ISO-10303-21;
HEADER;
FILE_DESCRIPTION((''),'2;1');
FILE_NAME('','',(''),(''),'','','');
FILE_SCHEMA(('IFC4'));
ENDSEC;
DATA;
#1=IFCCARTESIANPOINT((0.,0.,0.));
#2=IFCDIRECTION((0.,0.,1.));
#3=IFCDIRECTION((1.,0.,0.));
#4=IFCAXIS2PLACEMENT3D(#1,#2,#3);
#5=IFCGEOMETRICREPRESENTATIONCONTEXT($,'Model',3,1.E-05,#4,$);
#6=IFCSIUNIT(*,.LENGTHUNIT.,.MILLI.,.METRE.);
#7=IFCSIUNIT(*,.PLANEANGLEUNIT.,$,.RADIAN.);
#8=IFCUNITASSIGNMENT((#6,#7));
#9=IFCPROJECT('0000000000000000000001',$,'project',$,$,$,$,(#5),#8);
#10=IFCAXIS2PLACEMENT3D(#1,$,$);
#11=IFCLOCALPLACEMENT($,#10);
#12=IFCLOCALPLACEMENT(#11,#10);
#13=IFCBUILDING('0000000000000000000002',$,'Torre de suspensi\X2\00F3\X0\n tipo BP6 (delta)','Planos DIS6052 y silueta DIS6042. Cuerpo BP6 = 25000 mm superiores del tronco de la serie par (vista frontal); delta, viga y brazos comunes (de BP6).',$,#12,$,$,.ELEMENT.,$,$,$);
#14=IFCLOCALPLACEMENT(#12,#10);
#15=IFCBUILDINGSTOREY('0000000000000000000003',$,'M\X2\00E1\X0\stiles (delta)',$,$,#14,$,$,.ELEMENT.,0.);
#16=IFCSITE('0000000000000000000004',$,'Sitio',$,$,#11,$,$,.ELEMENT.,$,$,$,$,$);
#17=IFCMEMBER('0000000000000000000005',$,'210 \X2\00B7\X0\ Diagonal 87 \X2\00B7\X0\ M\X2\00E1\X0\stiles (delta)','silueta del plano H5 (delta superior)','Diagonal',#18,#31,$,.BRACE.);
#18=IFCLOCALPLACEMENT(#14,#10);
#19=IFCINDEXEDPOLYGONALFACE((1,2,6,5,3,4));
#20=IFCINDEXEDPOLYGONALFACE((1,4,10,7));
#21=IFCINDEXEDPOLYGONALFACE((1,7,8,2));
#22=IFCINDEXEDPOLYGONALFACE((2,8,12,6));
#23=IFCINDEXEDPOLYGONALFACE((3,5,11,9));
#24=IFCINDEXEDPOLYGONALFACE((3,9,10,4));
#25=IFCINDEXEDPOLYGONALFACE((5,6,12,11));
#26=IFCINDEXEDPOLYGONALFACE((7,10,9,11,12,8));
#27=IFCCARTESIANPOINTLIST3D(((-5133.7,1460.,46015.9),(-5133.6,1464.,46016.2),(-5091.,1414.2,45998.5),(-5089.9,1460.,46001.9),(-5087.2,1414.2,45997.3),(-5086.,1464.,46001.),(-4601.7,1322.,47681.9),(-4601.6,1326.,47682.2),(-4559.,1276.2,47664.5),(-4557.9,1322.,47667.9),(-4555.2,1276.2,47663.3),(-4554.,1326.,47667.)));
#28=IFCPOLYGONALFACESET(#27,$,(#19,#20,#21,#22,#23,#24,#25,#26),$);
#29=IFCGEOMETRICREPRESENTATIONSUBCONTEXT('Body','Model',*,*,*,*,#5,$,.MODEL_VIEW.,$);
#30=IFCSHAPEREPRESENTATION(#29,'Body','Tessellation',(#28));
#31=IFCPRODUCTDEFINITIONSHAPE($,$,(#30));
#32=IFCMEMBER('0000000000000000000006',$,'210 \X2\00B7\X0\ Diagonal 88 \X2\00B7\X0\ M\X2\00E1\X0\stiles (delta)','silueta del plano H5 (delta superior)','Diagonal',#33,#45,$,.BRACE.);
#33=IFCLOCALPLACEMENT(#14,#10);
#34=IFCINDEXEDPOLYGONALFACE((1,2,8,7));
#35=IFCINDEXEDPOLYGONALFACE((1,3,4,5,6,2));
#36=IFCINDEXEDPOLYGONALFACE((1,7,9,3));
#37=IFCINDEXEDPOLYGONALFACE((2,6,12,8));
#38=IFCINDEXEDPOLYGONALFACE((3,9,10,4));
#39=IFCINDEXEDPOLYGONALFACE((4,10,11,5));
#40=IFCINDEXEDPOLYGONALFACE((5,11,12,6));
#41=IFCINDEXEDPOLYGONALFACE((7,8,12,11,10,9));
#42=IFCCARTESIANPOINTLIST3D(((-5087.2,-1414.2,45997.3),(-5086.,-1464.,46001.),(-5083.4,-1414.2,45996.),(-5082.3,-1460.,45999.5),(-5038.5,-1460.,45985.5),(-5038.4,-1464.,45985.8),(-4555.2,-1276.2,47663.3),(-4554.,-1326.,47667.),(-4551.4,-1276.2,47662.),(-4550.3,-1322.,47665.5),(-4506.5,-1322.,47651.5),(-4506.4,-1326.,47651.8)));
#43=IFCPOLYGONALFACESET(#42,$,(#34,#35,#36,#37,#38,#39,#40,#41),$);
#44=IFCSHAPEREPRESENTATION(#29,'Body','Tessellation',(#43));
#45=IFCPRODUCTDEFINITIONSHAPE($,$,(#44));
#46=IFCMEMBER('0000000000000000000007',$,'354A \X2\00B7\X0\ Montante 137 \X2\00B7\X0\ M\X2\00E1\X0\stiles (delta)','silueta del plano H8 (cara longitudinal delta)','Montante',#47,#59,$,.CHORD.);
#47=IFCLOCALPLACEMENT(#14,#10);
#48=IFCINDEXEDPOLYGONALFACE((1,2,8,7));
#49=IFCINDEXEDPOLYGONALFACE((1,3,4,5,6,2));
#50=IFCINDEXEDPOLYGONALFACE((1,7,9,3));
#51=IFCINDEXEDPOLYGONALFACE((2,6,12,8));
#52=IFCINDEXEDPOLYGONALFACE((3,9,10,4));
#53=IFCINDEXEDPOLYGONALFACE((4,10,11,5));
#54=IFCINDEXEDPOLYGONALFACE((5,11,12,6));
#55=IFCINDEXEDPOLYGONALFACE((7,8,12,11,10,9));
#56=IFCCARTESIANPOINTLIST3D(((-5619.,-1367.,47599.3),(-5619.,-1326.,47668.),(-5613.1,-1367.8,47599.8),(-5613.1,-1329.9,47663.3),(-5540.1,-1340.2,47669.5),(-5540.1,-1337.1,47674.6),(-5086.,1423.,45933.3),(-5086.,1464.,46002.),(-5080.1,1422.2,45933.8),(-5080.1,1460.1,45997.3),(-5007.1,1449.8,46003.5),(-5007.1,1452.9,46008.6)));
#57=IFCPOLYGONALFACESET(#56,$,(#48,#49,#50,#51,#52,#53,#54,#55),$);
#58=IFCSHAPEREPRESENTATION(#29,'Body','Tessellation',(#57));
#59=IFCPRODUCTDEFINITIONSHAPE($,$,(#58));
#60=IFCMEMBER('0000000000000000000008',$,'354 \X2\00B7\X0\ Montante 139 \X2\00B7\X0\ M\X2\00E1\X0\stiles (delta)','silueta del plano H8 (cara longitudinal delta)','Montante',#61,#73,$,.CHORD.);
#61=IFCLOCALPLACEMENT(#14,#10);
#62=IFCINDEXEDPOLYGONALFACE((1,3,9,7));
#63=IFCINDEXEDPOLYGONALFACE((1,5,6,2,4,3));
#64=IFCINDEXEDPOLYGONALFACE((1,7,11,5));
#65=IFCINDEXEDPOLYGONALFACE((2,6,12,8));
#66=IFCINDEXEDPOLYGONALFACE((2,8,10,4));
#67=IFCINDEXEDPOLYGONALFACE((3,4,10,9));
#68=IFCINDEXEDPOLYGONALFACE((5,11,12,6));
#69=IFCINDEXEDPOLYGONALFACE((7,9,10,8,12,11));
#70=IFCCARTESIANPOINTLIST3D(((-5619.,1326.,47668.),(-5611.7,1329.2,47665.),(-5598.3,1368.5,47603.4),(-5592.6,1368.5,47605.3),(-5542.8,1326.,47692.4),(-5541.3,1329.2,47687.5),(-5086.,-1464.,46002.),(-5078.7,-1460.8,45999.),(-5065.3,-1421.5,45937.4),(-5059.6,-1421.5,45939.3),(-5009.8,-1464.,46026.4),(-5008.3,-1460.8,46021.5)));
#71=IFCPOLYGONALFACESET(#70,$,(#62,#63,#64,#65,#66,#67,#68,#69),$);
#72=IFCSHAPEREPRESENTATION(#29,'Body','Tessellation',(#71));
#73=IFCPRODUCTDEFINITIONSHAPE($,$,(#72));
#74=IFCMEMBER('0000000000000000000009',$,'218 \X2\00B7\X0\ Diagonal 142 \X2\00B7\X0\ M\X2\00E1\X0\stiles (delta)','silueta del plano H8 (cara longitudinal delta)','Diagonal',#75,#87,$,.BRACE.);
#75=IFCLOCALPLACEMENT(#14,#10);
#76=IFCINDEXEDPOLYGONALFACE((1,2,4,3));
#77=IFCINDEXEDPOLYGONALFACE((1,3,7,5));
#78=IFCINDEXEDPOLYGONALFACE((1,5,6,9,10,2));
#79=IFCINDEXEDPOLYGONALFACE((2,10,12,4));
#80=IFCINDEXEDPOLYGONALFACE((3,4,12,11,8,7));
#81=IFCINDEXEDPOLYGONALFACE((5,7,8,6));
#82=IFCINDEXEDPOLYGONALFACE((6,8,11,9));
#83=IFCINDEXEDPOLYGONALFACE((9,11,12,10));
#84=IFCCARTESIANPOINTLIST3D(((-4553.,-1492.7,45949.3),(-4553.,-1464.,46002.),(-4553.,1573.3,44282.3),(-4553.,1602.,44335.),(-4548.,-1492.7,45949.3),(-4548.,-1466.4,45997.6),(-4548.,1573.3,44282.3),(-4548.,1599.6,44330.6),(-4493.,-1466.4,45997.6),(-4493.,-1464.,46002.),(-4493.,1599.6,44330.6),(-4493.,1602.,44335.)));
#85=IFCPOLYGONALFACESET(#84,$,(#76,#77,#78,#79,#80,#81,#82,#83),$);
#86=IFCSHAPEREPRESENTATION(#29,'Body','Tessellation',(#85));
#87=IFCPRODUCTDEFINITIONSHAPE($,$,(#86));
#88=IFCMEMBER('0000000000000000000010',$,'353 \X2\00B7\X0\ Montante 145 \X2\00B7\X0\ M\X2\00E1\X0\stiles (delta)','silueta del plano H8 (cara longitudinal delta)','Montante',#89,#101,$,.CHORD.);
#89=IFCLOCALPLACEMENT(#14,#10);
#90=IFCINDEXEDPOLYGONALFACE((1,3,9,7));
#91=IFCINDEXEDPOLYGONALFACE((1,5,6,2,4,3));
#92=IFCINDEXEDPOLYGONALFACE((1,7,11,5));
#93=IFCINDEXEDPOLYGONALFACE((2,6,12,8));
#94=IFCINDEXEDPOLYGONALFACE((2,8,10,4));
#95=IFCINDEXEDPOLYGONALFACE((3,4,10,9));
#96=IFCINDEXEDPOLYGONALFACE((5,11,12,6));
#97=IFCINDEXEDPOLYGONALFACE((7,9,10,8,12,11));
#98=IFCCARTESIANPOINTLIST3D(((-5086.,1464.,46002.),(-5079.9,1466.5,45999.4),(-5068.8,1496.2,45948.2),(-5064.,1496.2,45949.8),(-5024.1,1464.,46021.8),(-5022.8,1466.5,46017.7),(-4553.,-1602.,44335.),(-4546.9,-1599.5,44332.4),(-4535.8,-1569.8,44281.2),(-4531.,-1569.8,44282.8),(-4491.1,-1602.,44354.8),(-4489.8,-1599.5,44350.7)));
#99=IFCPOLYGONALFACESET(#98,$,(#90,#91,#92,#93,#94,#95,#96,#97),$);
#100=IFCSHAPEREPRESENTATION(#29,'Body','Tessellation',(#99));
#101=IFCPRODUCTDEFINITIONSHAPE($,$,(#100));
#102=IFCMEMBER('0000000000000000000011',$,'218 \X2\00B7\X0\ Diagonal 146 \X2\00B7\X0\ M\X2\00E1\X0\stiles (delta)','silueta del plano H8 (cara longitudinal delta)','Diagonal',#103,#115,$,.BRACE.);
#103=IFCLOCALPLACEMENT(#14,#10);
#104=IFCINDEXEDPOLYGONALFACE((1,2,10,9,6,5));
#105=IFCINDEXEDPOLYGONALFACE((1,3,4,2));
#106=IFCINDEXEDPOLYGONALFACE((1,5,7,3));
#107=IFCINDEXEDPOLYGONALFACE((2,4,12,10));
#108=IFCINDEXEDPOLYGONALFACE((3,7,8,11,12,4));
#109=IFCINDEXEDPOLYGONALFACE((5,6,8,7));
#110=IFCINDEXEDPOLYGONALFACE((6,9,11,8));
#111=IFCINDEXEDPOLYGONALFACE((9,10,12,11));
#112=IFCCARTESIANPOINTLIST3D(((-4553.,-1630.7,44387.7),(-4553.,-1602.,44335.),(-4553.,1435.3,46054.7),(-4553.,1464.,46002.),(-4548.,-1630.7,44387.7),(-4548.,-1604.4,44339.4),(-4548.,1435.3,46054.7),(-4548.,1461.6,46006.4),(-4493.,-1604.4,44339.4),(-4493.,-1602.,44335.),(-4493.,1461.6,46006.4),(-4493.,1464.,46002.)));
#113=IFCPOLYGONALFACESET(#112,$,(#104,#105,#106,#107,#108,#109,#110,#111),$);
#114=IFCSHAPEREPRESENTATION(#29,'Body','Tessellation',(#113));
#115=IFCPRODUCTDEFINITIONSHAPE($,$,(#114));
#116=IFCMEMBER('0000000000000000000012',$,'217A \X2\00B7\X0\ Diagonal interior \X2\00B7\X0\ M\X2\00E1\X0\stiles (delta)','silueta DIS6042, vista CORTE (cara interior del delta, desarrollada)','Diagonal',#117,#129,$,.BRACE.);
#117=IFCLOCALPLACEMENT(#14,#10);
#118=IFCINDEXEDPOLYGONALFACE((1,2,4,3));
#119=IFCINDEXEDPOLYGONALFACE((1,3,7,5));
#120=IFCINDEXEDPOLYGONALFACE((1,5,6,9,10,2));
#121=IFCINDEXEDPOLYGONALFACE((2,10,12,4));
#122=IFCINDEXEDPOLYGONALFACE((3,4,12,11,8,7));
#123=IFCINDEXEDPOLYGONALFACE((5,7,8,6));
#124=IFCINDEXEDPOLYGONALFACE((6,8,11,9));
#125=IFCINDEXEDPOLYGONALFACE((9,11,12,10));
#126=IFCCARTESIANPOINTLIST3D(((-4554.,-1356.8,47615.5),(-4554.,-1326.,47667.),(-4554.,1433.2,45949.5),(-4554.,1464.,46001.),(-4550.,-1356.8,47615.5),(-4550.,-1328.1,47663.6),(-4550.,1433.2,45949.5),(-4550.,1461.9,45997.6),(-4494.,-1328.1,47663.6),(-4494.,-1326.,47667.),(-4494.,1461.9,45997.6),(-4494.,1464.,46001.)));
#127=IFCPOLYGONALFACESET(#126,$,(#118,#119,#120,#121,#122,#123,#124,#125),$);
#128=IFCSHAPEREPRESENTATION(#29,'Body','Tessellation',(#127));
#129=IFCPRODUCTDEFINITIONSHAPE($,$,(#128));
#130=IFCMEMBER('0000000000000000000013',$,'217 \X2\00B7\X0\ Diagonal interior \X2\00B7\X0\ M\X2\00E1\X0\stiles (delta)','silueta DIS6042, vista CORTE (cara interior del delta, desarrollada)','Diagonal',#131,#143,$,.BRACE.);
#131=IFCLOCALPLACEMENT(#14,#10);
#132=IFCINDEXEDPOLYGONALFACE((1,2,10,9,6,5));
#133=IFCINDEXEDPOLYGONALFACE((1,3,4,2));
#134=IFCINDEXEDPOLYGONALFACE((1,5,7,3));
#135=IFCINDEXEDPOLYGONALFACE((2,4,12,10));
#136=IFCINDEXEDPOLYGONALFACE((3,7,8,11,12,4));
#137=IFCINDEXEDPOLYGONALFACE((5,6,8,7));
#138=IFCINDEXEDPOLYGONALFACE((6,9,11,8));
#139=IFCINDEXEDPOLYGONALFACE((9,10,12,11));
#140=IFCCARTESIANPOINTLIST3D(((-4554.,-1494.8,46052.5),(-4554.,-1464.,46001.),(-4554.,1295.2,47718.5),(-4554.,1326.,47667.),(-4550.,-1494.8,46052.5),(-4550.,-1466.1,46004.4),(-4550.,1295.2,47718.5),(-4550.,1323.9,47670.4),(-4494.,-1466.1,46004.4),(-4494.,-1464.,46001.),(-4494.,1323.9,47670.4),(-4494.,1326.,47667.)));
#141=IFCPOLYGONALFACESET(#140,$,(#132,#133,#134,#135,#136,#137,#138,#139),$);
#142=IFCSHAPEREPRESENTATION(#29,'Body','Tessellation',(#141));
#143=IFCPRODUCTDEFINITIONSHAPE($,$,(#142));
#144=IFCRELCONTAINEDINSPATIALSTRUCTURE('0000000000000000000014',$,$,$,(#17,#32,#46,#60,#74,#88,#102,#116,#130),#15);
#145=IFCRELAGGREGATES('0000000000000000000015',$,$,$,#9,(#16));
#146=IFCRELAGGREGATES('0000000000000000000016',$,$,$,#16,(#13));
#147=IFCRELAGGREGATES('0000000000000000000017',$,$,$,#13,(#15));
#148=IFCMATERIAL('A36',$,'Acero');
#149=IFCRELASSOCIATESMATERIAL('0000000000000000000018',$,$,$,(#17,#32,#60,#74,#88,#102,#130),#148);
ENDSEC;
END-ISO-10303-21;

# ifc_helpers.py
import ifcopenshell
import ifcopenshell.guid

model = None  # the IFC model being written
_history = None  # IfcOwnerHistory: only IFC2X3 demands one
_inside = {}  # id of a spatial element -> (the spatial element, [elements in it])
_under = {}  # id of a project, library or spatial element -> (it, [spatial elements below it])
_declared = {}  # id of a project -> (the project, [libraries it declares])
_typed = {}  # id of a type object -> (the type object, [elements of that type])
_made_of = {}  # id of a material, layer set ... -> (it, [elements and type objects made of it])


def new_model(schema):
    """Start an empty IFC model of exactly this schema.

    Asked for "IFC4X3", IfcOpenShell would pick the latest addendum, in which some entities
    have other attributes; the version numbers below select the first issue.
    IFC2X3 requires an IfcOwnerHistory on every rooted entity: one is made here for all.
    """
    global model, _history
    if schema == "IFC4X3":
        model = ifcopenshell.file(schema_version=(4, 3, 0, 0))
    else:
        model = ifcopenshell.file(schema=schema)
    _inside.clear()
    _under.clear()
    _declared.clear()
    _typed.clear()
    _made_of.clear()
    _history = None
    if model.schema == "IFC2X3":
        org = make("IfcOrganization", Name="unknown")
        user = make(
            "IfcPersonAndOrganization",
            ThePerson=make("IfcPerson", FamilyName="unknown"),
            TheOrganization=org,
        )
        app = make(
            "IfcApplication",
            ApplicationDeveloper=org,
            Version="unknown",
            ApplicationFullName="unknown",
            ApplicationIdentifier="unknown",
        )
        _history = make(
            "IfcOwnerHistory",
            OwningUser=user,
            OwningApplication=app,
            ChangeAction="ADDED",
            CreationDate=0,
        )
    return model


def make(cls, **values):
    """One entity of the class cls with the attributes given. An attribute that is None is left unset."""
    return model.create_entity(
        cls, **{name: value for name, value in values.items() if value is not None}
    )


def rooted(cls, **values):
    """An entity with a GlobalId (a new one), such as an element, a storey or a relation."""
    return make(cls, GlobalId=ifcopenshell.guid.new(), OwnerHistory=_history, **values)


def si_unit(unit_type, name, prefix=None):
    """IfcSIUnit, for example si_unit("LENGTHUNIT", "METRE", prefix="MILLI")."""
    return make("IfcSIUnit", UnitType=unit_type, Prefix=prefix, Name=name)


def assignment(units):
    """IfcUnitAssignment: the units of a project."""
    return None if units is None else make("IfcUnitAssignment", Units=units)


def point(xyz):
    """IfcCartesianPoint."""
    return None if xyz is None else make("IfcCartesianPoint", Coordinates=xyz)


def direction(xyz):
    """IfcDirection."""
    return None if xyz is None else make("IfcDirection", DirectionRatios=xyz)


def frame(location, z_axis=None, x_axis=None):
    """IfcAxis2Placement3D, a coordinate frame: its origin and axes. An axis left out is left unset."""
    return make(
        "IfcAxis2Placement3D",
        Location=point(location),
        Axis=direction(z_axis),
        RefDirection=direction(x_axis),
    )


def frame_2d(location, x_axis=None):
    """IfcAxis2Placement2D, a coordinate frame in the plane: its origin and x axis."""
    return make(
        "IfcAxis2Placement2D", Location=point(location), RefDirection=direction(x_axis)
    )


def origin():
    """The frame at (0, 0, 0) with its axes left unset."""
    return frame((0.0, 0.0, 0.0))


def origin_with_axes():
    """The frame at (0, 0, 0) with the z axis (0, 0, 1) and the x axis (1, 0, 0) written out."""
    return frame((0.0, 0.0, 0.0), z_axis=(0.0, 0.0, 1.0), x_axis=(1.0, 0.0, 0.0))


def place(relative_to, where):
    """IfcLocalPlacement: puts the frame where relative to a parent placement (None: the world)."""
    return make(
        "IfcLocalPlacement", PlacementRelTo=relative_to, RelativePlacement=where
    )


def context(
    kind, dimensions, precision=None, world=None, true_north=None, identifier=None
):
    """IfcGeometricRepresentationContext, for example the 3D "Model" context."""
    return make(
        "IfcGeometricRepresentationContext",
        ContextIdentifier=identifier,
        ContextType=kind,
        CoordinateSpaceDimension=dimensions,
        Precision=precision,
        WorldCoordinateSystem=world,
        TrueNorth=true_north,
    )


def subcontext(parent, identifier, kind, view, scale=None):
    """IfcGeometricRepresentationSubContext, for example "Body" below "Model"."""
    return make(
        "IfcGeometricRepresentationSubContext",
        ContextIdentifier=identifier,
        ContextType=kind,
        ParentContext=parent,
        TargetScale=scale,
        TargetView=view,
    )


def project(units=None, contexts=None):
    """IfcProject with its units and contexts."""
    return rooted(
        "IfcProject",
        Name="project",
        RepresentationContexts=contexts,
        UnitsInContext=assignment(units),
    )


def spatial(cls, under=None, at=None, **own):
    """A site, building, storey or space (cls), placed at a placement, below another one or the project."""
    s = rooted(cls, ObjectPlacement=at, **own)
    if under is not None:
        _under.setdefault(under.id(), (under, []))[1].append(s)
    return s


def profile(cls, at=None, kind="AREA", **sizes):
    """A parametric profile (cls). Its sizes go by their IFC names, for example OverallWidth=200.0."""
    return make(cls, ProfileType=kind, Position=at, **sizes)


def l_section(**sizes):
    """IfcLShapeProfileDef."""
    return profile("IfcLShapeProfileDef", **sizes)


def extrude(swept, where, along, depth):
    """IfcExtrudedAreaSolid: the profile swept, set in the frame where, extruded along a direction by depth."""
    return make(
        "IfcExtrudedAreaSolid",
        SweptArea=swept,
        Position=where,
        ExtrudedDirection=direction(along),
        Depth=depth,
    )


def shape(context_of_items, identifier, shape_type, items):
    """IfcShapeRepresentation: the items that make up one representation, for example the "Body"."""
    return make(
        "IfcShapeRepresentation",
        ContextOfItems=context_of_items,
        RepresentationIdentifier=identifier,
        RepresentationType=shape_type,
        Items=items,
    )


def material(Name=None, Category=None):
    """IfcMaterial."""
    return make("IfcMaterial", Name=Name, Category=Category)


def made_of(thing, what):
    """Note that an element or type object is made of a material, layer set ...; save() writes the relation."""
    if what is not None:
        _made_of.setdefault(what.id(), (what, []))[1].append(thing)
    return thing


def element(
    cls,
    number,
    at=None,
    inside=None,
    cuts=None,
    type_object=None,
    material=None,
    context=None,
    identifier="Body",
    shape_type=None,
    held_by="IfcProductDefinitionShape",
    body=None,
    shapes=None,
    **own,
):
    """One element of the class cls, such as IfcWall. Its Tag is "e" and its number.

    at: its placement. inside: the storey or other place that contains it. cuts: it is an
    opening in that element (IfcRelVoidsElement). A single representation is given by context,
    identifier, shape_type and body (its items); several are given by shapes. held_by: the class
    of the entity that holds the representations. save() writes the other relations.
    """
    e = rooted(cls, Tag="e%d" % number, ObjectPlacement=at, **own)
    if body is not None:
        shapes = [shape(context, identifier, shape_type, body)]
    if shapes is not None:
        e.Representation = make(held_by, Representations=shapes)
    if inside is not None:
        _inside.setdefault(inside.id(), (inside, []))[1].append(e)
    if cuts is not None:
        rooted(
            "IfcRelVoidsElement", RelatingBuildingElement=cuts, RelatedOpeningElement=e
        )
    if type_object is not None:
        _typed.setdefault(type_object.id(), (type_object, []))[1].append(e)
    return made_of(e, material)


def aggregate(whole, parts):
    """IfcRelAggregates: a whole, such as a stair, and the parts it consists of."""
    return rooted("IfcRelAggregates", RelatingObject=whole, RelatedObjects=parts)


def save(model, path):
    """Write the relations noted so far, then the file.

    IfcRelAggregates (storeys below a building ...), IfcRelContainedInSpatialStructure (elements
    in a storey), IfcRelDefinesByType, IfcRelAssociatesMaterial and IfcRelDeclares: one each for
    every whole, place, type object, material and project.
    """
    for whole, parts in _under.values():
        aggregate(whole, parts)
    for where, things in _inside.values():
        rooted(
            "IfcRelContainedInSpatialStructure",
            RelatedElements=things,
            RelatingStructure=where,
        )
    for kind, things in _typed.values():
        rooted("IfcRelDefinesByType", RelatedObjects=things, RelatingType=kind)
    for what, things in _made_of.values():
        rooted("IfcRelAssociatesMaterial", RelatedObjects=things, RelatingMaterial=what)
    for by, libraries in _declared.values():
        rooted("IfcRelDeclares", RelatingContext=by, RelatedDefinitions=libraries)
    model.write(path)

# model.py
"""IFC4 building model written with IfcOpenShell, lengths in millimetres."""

from ifc_helpers import new_model, si_unit, frame, frame_2d, origin, origin_with_axes, place, context, subcontext, project, spatial, l_section, extrude, material, element, save


model = new_model("IFC4")

# Units and contexts
model_context = context("Model", 3, precision=1e-05, world=origin_with_axes())
body_context = subcontext(model_context, "Body", "Model", "MODEL_VIEW")
ifc_project = project(units=[si_unit("LENGTHUNIT", "METRE", prefix="MILLI"), si_unit("PLANEANGLEUNIT", "RADIAN")], contexts=[model_context])

# Site, building, storey
site_placement = place(None, origin())
site = spatial("IfcSite", under=ifc_project, at=site_placement, Name="Sitio", CompositionType="ELEMENT")
building_placement = place(site_placement, origin())
building = spatial("IfcBuilding", under=site, at=building_placement, Name="Torre de suspensión tipo BP6 (delta)", Description="Planos DIS6052 y silueta DIS6042. Cuerpo BP6 = 25000 mm superiores del tronco de la serie par (vista frontal); delta, viga y brazos comunes (de BP6).", CompositionType="ELEMENT")
storey_placement = place(building_placement, origin())
storey = spatial("IfcBuildingStorey", under=building, at=storey_placement, Name="Mástiles (delta)", CompositionType="ELEMENT", Elevation=0.0)

# Members
ifc_material_1 = material(Name="A36", Category="Acero")
for number, where, z_axis, x_axis, name in (
    (1, (-4554.0, 1326.0, 47667.0), (-0.303252, 0.078663, -0.949658), (-0.023929, -0.996901, -0.074935), "210 · Diagonal 87 · Mástiles (delta)"),
    (2, (-4554.0, -1326.0, 47667.0), (-0.303252, -0.078663, -0.949658), (-0.023929, 0.996901, -0.074935), "210 · Diagonal 88 · Mástiles (delta)"),
):
    element("IfcMember", number, at=place(storey_placement, frame(where, z_axis=z_axis, x_axis=x_axis)), inside=storey, material=ifc_material_1, Name=name, Description="silueta del plano H5 (delta superior)", ObjectType="Diagonal", PredefinedType="BRACE", context=body_context, shape_type="SweptSolid", body=[
        extrude(l_section(Depth=50.0, Width=50.0, Thickness=4.0, at=frame_2d((25.0, 25.0))), None, (0.0, 0.0, 1.0), 1754.3),
    ])
member_1_placement = place(storey_placement, frame((-5619.0, -1326.0, 47668.0), z_axis=(0.161859, 0.847256, -0.505924), x_axis=(0.986814, -0.138969, 0.082983)))
element("IfcMember", 3, at=member_1_placement, inside=storey, Name="354A · Montante 137 · Mástiles (delta)", Description="silueta del plano H8 (cara longitudinal delta)", ObjectType="Montante", PredefinedType="CHORD", context=body_context, shape_type="SweptSolid", body=[
    extrude(l_section(Depth=80.0, Width=80.0, Thickness=6.0, at=frame_2d((40.0, 40.0))), None, (0.0, 0.0, 1.0), 3293.0),
])
member_2_placement = place(storey_placement, frame((-5619.0, 1326.0, 47668.0), z_axis=(0.161859, -0.847256, -0.505924), x_axis=(0.25817, 0.531185, -0.806964)))
element("IfcMember", 4, at=member_2_placement, inside=storey, material=ifc_material_1, Name="354 · Montante 139 · Mástiles (delta)", Description="silueta del plano H8 (cara longitudinal delta)", ObjectType="Montante", PredefinedType="CHORD", context=body_context, shape_type="SweptSolid", body=[
    extrude(l_section(Depth=80.0, Width=80.0, Thickness=6.0, at=frame_2d((40.0, 40.0))), None, (0.0, 0.0, 1.0), 3293.0),
])
member_3_placement = place(storey_placement, frame((-4553.0, -1464.0, 46002.0), z_axis=(0.0, 0.878541, -0.477667), x_axis=(1.0, 0.0, 0.0)))
element("IfcMember", 5, at=member_3_placement, inside=storey, material=ifc_material_1, Name="218 · Diagonal 142 · Mástiles (delta)", Description="silueta del plano H8 (cara longitudinal delta)", ObjectType="Diagonal", PredefinedType="BRACE", context=body_context, shape_type="SweptSolid", body=[
    extrude(l_section(Depth=60.0, Width=60.0, Thickness=5.0, at=frame_2d((30.0, 30.0))), None, (0.0, 0.0, 1.0), 3489.9),
])
member_4_placement = place(storey_placement, frame((-5086.0, 1464.0, 46002.0), z_axis=(0.150977, -0.86847, -0.472192), x_axis=(0.264491, 0.495741, -0.827216)))
element("IfcMember", 6, at=member_4_placement, inside=storey, material=ifc_material_1, Name="353 · Montante 145 · Mástiles (delta)", Description="silueta del plano H8 (cara longitudinal delta)", ObjectType="Montante", PredefinedType="CHORD", context=body_context, shape_type="SweptSolid", body=[
    extrude(l_section(Depth=65.0, Width=65.0, Thickness=5.0, at=frame_2d((32.5, 32.5))), None, (0.0, 0.0, 1.0), 3530.3),
])
member_5_placement = place(storey_placement, frame((-4553.0, 1464.0, 46002.0), z_axis=(0.0, -0.878541, -0.477667), x_axis=(1.0, 0.0, 0.0)))
element("IfcMember", 7, at=member_5_placement, inside=storey, material=ifc_material_1, Name="218 · Diagonal 146 · Mástiles (delta)", Description="silueta del plano H8 (cara longitudinal delta)", ObjectType="Diagonal", PredefinedType="BRACE", context=body_context, shape_type="SweptSolid", body=[
    extrude(l_section(Depth=60.0, Width=60.0, Thickness=5.0, at=frame_2d((30.0, 30.0))), None, (0.0, 0.0, 1.0), 3489.9),
])
member_6_placement = place(storey_placement, frame((-4554.0, -1326.0, 47667.0), z_axis=(0.0, 0.858577, -0.512684), x_axis=(1.0, 0.0, 0.0)))
element("IfcMember", 8, at=member_6_placement, inside=storey, Name="217A · Diagonal interior · Mástiles (delta)", Description="silueta DIS6042, vista CORTE (cara interior del delta, desarrollada)", ObjectType="Diagonal", PredefinedType="BRACE", context=body_context, shape_type="SweptSolid", body=[
    extrude(l_section(Depth=60.0, Width=60.0, Thickness=4.0, at=frame_2d((30.0, 30.0))), None, (0.0, 0.0, 1.0), 3249.6),
])
member_7_placement = place(storey_placement, frame((-4554.0, 1326.0, 47667.0), z_axis=(0.0, -0.858577, -0.512684), x_axis=(1.0, 0.0, 0.0)))
element("IfcMember", 9, at=member_7_placement, inside=storey, material=ifc_material_1, Name="217 · Diagonal interior · Mástiles (delta)", Description="silueta DIS6042, vista CORTE (cara interior del delta, desarrollada)", ObjectType="Diagonal", PredefinedType="BRACE", context=body_context, shape_type="SweptSolid", body=[
    extrude(l_section(Depth=60.0, Width=60.0, Thickness=4.0, at=frame_2d((30.0, 30.0))), None, (0.0, 0.0, 1.0), 3249.6),
])

save(model, "model.ifc")
